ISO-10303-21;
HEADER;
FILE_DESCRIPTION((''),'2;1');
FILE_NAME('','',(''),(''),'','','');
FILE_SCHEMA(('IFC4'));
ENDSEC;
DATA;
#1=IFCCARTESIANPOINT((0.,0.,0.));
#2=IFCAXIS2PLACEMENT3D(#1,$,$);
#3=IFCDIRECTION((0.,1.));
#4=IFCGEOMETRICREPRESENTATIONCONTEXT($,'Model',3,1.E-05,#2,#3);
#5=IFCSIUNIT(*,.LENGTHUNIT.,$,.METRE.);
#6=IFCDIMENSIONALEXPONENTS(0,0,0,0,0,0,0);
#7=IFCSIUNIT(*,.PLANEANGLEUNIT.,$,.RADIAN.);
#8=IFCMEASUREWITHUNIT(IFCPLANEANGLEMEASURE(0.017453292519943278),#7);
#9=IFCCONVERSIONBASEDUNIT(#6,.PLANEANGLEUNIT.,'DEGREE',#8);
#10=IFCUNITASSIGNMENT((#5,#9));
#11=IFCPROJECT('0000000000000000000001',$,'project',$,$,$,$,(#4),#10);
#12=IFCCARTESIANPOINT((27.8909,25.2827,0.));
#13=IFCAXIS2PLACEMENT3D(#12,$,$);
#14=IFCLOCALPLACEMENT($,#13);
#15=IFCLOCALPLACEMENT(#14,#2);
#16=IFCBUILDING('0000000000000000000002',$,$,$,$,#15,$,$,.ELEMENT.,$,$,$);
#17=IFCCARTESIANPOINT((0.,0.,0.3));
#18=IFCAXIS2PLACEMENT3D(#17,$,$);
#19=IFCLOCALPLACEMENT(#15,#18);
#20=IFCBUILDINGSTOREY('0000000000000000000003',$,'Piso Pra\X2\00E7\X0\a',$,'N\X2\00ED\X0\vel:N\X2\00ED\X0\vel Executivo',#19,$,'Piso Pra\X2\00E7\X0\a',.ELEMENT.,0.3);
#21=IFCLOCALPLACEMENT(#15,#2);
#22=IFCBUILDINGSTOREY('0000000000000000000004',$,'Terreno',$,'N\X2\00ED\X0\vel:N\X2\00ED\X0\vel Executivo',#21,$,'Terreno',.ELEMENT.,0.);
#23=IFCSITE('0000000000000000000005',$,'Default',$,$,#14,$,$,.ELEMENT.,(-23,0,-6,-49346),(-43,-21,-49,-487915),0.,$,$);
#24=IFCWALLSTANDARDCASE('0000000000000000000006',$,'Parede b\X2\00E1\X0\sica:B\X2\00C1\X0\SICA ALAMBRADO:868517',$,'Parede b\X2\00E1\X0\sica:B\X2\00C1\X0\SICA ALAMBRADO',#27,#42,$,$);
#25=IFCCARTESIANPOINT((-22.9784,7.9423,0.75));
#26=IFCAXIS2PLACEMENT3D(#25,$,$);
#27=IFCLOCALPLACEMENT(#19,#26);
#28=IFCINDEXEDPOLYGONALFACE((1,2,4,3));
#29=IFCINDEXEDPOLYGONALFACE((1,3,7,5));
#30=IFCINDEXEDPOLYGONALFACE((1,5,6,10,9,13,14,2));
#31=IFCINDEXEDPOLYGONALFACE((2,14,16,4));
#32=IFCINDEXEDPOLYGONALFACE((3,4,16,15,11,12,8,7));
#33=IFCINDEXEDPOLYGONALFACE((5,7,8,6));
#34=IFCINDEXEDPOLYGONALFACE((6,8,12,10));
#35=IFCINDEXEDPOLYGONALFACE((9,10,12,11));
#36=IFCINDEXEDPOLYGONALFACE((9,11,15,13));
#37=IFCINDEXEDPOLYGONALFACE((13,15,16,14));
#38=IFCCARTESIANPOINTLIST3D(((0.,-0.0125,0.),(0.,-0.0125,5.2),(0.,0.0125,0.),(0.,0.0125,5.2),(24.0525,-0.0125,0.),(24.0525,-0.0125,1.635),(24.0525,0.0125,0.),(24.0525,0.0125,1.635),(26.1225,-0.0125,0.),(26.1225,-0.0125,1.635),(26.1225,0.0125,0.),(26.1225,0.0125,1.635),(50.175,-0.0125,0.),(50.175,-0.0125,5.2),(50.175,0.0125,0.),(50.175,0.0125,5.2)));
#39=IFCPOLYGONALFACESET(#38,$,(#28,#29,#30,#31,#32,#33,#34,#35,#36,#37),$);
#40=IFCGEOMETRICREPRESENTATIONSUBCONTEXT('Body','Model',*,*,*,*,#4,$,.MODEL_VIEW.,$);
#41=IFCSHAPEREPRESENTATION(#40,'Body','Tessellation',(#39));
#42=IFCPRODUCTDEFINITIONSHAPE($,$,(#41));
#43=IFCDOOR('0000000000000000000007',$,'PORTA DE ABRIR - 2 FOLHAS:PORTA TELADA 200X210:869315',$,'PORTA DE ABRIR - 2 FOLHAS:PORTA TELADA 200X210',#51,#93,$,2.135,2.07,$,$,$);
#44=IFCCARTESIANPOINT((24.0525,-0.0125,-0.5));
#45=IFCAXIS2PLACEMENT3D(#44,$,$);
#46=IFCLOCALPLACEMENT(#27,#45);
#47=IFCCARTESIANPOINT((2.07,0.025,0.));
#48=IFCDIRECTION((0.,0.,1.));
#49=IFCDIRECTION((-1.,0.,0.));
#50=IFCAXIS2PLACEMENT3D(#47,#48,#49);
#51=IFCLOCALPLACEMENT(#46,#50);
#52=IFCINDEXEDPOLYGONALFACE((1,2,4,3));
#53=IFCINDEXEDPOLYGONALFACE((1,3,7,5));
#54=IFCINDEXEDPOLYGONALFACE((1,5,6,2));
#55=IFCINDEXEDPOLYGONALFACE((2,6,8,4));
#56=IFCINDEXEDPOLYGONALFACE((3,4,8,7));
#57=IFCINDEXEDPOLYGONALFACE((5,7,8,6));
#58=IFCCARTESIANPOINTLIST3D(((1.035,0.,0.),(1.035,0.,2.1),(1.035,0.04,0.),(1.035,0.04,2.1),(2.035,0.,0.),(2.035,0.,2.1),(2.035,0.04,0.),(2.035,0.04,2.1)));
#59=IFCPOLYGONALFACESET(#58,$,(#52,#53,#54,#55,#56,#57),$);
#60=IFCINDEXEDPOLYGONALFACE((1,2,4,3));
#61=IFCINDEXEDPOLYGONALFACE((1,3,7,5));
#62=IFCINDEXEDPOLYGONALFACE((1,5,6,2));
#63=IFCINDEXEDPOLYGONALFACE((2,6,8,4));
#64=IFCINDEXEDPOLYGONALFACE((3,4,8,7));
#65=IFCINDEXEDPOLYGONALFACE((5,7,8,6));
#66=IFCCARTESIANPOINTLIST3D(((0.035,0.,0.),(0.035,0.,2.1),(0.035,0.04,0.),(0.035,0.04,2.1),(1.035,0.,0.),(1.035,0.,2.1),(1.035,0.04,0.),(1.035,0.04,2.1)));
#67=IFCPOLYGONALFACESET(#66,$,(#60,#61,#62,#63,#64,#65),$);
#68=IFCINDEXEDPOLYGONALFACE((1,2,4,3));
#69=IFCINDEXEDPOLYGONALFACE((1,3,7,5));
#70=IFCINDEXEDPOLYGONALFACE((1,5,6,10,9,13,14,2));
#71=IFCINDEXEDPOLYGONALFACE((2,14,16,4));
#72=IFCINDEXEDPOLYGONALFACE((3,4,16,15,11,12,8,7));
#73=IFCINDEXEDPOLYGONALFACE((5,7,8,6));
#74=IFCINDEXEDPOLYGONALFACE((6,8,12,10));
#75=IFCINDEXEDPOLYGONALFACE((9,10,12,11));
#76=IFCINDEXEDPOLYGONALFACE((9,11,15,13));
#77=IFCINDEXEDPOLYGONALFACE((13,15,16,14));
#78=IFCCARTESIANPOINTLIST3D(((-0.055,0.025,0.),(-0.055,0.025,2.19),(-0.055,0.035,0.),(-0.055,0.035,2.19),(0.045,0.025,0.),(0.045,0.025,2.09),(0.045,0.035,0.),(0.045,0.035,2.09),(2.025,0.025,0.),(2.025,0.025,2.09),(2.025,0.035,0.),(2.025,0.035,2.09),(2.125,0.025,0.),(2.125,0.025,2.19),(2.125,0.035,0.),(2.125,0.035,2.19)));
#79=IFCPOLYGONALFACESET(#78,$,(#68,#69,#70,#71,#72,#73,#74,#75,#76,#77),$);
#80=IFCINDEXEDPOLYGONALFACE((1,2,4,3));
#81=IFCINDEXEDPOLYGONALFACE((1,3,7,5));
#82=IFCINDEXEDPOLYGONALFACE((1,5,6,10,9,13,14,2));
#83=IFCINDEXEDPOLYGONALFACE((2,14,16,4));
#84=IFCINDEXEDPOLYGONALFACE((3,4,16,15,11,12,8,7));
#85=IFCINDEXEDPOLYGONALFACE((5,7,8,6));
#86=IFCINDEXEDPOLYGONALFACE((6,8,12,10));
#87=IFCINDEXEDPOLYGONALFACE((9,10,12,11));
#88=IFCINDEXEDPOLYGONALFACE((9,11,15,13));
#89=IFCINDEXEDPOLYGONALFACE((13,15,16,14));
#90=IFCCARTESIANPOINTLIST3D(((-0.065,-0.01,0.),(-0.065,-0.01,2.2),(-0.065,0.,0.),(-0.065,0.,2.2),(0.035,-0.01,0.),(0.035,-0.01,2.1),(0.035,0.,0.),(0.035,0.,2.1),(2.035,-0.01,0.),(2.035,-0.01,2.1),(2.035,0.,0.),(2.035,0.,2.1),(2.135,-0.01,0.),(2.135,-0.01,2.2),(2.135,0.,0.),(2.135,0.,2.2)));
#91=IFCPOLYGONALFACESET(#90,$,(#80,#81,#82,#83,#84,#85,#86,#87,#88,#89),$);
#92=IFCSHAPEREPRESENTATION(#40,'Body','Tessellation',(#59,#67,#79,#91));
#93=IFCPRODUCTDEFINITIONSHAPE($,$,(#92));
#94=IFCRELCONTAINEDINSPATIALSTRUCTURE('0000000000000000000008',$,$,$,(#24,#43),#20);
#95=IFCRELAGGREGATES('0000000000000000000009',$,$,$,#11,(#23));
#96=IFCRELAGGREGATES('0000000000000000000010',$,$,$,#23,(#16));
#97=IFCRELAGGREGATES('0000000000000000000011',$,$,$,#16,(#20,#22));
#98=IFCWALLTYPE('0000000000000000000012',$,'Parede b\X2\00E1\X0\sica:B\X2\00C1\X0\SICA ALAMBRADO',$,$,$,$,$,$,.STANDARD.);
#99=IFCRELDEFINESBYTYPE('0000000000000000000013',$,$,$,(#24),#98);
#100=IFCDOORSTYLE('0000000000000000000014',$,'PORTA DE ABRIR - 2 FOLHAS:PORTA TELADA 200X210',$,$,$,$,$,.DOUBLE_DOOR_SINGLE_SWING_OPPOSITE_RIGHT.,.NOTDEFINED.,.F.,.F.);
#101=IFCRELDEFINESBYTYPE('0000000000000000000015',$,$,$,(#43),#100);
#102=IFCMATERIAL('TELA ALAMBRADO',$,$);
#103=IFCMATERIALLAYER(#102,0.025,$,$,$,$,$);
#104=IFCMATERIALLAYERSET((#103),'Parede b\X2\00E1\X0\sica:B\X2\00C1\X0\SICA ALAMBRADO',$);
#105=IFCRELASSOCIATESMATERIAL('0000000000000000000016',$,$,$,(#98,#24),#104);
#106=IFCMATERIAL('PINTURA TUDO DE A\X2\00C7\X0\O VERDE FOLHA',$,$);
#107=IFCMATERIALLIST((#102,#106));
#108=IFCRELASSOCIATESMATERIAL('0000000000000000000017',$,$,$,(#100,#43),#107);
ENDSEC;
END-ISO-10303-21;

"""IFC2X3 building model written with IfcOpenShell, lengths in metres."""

from ifc_helpers import new_model, entity, si_unit, converted_unit, direction, frame, frame_2d, origin, origin_2d_with_axis, place, context, subcontext, project, spatial, polyline, rectangle, outline, extrude, source, transform, mapped, material, material_list, layer, layer_set, layer_usage, type_object, type_shapes, element, fill, save


model = new_model("IFC2X3")

# Units and contexts
model_context = context("Model", 3, precision=1e-05, world=origin(), true_north=direction((0.0, 1.0)))
body_context = subcontext(model_context, "Body", "Model", "MODEL_VIEW")
ifc_project = project(units=[si_unit("LENGTHUNIT", "METRE"), converted_unit("PLANEANGLEUNIT", "DEGREE", entity("IfcPlaneAngleMeasure", 0.017453292519943278), si_unit("PLANEANGLEUNIT", "RADIAN"), dimensions=[0, 0, 0, 0, 0, 0, 0])], contexts=[model_context])

# Site, building, storey
site_placement = place(None, frame((27.8909, 25.2827, 0.0)))
site = spatial("IfcSite", under=ifc_project, at=site_placement, Name="Default", CompositionType="ELEMENT", RefLatitude=(-23, 0, -6, -49346), RefLongitude=(-43, -21, -49, -487915), RefElevation=0.0)
building_placement = place(site_placement, origin())
building = spatial("IfcBuilding", under=site, at=building_placement, CompositionType="ELEMENT")
storey_1_placement = place(building_placement, frame((0.0, 0.0, 0.3)))
storey_1 = spatial("IfcBuildingStorey", under=building, at=storey_1_placement, Name="Piso Praça", ObjectType="Nível:Nível Executivo", LongName="Piso Praça", CompositionType="ELEMENT", Elevation=0.3)

# Shared definitions
ifc_material_1 = material(Name="PINTURA TUDO DE AÇO VERDE FOLHA")

# Wall, opening, door
ifc_material_2 = material(Name="TELA ALAMBRADO")
ifc_layer_1 = layer(ifc_material_2, 0.025)
ifc_layer_set_1 = layer_set([ifc_layer_1], Name="Parede básica:BÁSICA ALAMBRADO")
ifc_layer_usage_1 = layer_usage(ifc_layer_set_1, "AXIS2", "NEGATIVE", 0.0125)
wall_type_1 = type_object("IfcWallType", Name="Parede básica:BÁSICA ALAMBRADO", PredefinedType="STANDARD", material=ifc_layer_set_1)
wall_1_placement = place(storey_1_placement, frame((-22.9784, 7.9423, 0.75)))
wall_1 = element("IfcWallStandardCase", 1, at=wall_1_placement, inside=storey_1, type_object=wall_type_1, material=ifc_layer_usage_1, Name="Parede básica:BÁSICA ALAMBRADO:868517", ObjectType="Parede básica:BÁSICA ALAMBRADO", context=body_context, shape_type="SweptSolid", body=[
    extrude(rectangle(XDim=50.175, YDim=0.025, at=frame_2d((25.0875, 0.0), x_axis=(-1.0, 0.0))), origin(), (0.0, 0.0, 1.0), 5.2),
])
opening_1_placement = place(wall_1_placement, frame((24.0525, -0.0125, -0.5)))
opening_1 = element("IfcOpeningElement", 2, at=opening_1_placement, cuts=wall_1, ObjectType="Opening", context=body_context, shape_type="SweptSolid", body=[
    extrude(rectangle(XDim=2.135, YDim=2.07, at=frame_2d((1.0675, 1.035), x_axis=(1.0, 0.0))), frame((0.0, 0.0, 0.0), z_axis=(0.0, 1.0, 0.0), x_axis=(0.0, 0.0, 1.0)), (0.0, 0.0, 1.0), 0.025),
])
ifc_material_list = material_list([ifc_material_2, ifc_material_1])
door_style = type_object("IfcDoorStyle", Name="PORTA DE ABRIR - 2 FOLHAS:PORTA TELADA 200X210", ConstructionType="NOTDEFINED", OperationType="DOUBLE_DOOR_SINGLE_SWING_OPPOSITE_RIGHT", ParameterTakesPrecedence=False, Sizeable=False, material=ifc_material_list)
shared_shape_1 = source(origin(), body_context, "Body", "SweptSolid", [
    extrude(rectangle(XDim=1.0, YDim=0.04, at=origin_2d_with_axis()), frame((1.535, 0.02, 0.0)), (0.0, 0.0, 1.0), 2.1),
    extrude(rectangle(XDim=0.04, YDim=1.0, at=origin_2d_with_axis()), frame((0.535, 0.02, 0.0), z_axis=(0.0, 0.0, 1.0), x_axis=(0.0, 1.0, 0.0)), (0.0, 0.0, 1.0), 2.1),
    extrude(outline(polyline([(-0.99, -1.02), (-0.99, 1.07), (-1.09, 1.07), (-1.09, -1.12), (1.09, -1.12), (1.09, 1.07), (0.99, 1.07), (0.99, -1.02), (-0.99, -1.02)])), frame((1.035, 0.025, 1.07), z_axis=(0.0, -1.0, 0.0), x_axis=(-1.0, 0.0, 0.0)), (0.0, 0.0, -1.0), 0.01),
    extrude(outline(polyline([(-1.025, 1.0), (1.075, 1.0), (1.075, 1.1), (-1.125, 1.1), (-1.125, -1.1), (1.075, -1.1), (1.075, -1.0), (-1.025, -1.0), (-1.025, 1.0)])), frame((1.035, -0.01, 1.075), z_axis=(0.0, 1.0, 0.0), x_axis=(0.0, 0.0, -1.0)), (0.0, 0.0, 1.0), 0.01),
])
type_shapes(door_style, [shared_shape_1])
door_placement = place(opening_1_placement, frame((2.07, 0.025, 0.0), z_axis=(0.0, 0.0, 1.0), x_axis=(-1.0, 0.0, 0.0)))
door = element("IfcDoor", 3, at=door_placement, inside=storey_1, type_object=door_style, material=ifc_material_list, Name="PORTA DE ABRIR - 2 FOLHAS:PORTA TELADA 200X210:869315", ObjectType="PORTA DE ABRIR - 2 FOLHAS:PORTA TELADA 200X210", OverallHeight=2.135, OverallWidth=2.07, context=body_context, shape_type="MappedRepresentation", body=[
    mapped(shared_shape_1, transform((0.0, 0.0, 0.0), scale=1.0)),
])
fill(opening_1, door)

# Shared definitions
storey_2_placement = place(building_placement, origin())
storey_2 = spatial("IfcBuildingStorey", under=building, at=storey_2_placement, Name="Terreno", ObjectType="Nível:Nível Executivo", LongName="Terreno", CompositionType="ELEMENT", Elevation=0.0)

save(model, "model.ifc")
